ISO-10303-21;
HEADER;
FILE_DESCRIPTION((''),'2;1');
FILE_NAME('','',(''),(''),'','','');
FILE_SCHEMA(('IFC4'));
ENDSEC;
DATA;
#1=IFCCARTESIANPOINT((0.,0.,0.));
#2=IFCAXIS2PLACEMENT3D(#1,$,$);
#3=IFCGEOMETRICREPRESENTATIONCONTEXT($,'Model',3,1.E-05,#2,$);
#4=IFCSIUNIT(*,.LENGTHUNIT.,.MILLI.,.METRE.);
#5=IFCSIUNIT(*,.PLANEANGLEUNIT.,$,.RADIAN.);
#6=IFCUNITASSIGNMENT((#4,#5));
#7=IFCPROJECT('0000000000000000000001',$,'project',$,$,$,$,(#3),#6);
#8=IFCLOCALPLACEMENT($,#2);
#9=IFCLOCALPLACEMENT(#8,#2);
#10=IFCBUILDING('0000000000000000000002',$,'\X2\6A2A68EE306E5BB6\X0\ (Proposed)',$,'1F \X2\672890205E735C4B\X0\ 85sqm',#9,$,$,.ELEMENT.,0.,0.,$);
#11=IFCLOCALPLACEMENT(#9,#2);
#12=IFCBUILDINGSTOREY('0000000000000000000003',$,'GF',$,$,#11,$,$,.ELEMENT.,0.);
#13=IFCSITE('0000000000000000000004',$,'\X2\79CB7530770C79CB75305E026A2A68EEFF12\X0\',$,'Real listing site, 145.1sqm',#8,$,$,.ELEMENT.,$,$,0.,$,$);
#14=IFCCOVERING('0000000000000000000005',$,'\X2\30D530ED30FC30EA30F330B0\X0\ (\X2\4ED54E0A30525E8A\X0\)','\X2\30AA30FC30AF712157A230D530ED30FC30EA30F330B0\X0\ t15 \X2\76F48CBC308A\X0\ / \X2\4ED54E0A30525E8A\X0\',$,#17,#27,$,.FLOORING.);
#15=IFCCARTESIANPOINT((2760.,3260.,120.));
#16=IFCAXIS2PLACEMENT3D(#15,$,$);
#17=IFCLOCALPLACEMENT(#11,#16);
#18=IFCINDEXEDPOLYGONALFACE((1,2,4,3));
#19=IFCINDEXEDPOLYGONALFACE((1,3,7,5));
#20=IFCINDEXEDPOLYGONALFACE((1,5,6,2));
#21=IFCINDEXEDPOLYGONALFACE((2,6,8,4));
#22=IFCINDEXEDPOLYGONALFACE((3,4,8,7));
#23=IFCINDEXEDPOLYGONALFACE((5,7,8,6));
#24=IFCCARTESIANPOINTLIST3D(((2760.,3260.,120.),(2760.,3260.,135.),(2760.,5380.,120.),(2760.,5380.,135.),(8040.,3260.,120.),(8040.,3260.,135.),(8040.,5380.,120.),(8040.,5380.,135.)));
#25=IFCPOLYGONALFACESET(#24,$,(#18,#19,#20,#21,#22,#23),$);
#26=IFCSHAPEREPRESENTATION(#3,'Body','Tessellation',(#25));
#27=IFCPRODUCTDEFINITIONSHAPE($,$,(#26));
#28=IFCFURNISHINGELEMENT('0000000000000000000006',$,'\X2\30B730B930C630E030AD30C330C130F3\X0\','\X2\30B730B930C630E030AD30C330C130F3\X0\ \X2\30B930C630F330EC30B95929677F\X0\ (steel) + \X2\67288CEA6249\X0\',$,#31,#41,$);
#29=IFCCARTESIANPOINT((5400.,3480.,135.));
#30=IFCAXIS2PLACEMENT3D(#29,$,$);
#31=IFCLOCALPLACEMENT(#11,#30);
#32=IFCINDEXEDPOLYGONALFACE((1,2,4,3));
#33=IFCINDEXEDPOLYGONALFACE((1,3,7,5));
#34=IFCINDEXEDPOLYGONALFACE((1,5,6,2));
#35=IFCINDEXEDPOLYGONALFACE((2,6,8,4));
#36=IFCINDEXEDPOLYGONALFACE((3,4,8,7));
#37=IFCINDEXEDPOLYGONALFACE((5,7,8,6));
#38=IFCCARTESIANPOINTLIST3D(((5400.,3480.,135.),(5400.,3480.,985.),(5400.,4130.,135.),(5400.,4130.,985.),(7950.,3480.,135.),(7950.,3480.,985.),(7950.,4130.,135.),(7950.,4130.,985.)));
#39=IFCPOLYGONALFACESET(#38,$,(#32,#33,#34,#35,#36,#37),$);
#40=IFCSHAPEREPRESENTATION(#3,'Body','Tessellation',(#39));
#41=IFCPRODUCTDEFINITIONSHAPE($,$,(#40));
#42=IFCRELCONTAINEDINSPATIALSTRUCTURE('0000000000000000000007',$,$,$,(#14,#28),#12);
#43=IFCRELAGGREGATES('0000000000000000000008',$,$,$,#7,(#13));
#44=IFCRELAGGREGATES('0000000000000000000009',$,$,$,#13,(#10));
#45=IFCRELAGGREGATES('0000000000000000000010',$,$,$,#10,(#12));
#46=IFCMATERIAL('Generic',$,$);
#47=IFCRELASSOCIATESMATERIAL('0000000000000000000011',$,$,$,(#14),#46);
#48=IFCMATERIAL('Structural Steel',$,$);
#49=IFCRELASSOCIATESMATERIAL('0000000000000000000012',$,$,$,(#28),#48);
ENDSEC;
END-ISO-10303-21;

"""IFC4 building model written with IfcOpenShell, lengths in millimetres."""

from ifc_helpers import new_model, si_unit, frame, frame_2d, origin, place, context, project, spatial, rectangle, extrude, material, element, save


model = new_model("IFC4")

# Units and contexts
model_context = context("Model", 3, precision=1e-05, world=origin())
ifc_project = project(units=[si_unit("LENGTHUNIT", "METRE", prefix="MILLI"), si_unit("PLANEANGLEUNIT", "RADIAN")], contexts=[model_context])

# Site, building, storey
site_placement = place(None, origin())
site = spatial("IfcSite", under=ifc_project, at=site_placement, Name="秋田県秋田市横森２", ObjectType="Real listing site, 145.1sqm", CompositionType="ELEMENT", RefElevation=0.0)
building_placement = place(site_placement, origin())
building = spatial("IfcBuilding", under=site, at=building_placement, Name="横森の家 (Proposed)", ObjectType="1F 木造平屋 85sqm", CompositionType="ELEMENT", ElevationOfRefHeight=0.0, ElevationOfTerrain=0.0)
storey_placement = place(building_placement, origin())
storey = spatial("IfcBuildingStorey", under=building, at=storey_placement, Name="GF", CompositionType="ELEMENT", Elevation=0.0)

# Shared definitions
ifc_material_1 = material(Name="Generic")

# Covering
covering_placement = place(storey_placement, frame((2760.0, 3260.0, 120.0)))
element("IfcCovering", 1, at=covering_placement, inside=storey, material=ifc_material_1, Name="フローリング (仕上げ床)", Description="オーク無垢フローリング t15 直貼り / 仕上げ床", PredefinedType="FLOORING", context=model_context, shape_type="SweptSolid", body=[
    extrude(rectangle(XDim=5280.0, YDim=2120.0, at=frame_2d((2640.0, 1060.0))), frame((2760.0, 3260.0, 120.0)), (0.0, 0.0, 1.0), 15.0),
])

# Furnishing element
ifc_material_2 = material(Name="Structural Steel")
furnishing_placement = place(storey_placement, frame((5400.0, 3480.0, 135.0)))
element("IfcFurnishingElement", 2, at=furnishing_placement, inside=storey, material=ifc_material_2, Name="システムキッチン", Description="システムキッチン ステンレス天板 (steel) + 木質扉", context=model_context, shape_type="SweptSolid", body=[
    extrude(rectangle(XDim=2550.0, YDim=650.0, at=frame_2d((1275.0, 325.0))), frame((5400.0, 3480.0, 135.0)), (0.0, 0.0, 1.0), 850.0),
])

save(model, "model.ifc")
